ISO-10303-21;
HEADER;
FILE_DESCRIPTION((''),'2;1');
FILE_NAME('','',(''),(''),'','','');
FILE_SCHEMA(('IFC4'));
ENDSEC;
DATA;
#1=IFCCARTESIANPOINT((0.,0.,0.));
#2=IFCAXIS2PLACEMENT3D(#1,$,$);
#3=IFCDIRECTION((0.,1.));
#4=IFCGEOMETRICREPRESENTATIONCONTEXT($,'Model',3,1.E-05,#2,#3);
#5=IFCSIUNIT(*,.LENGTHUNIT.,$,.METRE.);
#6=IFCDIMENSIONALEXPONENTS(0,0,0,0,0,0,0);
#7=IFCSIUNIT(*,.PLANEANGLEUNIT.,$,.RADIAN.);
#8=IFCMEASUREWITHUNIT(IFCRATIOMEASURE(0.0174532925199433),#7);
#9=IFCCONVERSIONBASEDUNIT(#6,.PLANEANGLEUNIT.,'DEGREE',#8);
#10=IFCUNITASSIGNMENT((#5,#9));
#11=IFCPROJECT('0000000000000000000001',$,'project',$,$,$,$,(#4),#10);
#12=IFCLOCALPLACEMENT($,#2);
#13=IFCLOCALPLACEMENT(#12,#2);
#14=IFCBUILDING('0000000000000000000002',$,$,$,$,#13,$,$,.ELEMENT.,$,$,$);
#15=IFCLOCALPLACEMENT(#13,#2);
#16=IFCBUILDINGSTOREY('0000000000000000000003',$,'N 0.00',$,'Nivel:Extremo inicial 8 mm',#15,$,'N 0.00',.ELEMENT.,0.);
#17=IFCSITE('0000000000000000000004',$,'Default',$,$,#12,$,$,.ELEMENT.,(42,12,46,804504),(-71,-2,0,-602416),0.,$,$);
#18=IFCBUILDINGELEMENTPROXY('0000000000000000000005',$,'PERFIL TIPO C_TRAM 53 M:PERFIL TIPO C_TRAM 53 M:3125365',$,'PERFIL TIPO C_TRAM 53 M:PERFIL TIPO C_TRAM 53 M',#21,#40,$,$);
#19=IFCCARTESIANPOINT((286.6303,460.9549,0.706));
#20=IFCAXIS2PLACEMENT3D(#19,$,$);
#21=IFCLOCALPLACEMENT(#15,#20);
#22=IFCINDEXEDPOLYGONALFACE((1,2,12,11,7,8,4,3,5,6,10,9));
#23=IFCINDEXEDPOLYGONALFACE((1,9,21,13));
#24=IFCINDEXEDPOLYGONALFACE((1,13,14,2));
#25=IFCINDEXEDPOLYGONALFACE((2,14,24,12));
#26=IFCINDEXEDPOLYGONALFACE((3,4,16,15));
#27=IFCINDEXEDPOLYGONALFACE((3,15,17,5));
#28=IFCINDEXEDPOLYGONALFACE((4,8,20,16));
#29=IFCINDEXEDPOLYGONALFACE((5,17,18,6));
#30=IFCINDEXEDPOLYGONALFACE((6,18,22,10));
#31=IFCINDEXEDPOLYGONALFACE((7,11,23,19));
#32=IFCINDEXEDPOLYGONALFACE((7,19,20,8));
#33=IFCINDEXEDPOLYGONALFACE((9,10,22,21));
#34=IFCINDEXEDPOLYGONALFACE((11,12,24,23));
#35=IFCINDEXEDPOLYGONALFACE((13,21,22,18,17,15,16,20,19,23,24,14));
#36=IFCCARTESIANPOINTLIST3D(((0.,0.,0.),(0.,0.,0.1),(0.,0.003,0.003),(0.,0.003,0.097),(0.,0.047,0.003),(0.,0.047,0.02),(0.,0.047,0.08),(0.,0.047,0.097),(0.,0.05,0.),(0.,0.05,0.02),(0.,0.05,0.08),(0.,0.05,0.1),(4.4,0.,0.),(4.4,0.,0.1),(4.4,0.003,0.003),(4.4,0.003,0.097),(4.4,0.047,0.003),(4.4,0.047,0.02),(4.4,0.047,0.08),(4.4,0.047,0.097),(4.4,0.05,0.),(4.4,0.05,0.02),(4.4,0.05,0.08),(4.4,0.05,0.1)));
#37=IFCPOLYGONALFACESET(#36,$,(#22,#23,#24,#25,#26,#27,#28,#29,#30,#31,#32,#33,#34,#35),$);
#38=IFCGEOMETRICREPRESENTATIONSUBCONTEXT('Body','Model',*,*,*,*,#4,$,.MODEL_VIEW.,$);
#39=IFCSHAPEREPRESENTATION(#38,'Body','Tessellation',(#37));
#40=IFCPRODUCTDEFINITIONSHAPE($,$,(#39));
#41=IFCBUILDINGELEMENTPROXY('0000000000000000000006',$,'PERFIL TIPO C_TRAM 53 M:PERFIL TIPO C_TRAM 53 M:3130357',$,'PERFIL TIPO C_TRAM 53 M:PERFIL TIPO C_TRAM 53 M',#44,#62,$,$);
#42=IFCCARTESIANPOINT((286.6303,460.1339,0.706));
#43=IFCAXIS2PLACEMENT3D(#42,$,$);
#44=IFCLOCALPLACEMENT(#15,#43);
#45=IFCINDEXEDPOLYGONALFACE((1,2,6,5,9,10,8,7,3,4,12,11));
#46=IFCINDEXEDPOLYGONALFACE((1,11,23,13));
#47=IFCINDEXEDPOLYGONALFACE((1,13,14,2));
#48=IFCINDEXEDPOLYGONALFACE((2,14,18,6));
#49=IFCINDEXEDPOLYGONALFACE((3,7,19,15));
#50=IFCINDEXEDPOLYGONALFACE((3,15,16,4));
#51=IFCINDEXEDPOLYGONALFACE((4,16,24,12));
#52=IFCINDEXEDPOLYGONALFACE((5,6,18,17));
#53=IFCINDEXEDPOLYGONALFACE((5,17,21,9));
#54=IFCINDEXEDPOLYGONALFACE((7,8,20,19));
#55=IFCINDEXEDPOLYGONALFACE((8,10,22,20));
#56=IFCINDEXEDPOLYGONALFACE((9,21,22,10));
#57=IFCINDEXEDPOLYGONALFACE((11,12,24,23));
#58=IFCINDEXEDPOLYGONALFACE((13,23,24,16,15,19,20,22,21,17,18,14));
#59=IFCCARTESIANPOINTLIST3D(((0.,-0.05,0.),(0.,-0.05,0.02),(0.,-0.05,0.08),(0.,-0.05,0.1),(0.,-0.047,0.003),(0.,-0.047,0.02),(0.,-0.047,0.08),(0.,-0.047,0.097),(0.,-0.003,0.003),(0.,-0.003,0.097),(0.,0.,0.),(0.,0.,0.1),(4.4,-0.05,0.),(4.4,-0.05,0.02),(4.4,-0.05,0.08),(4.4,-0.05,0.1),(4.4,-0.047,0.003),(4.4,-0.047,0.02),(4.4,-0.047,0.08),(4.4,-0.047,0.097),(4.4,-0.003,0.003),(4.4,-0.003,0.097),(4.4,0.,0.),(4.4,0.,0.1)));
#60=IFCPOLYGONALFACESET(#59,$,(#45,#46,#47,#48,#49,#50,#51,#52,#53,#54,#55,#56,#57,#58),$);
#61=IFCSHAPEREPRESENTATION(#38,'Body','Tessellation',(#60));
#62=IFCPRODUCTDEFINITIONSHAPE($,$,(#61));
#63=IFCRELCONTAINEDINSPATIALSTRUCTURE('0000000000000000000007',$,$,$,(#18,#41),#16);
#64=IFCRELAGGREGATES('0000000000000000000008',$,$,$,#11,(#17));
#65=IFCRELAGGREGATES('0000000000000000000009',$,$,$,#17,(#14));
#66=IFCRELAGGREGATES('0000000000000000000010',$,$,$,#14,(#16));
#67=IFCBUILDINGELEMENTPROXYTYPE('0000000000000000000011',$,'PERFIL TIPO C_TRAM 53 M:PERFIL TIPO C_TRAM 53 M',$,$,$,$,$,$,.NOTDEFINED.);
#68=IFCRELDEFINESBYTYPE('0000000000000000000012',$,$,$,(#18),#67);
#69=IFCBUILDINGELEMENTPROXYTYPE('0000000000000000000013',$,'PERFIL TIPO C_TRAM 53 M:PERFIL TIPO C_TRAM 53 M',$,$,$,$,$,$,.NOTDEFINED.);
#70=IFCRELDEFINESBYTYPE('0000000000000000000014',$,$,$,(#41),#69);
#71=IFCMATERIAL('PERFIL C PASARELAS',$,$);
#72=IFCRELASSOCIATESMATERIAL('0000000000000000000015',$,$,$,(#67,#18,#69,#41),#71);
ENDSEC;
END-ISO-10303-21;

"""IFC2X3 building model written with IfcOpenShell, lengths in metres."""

from ifc_helpers import new_model, entity, si_unit, converted_unit, direction, frame, origin, place, context, subcontext, project, spatial, polyline, outline, extrude, source, transform, mapped, material, type_object, type_shapes, element, save


model = new_model("IFC2X3")

# Units and contexts
model_context = context("Model", 3, precision=1e-05, world=origin(), true_north=direction((0.0, 1.0)))
body_context = subcontext(model_context, "Body", "Model", "MODEL_VIEW")
ifc_project = project(units=[si_unit("LENGTHUNIT", "METRE"), converted_unit("PLANEANGLEUNIT", "DEGREE", entity("IfcRatioMeasure", 0.0174532925199433), si_unit("PLANEANGLEUNIT", "RADIAN"), dimensions=[0, 0, 0, 0, 0, 0, 0])], contexts=[model_context])

# Site, building, storey
site_placement = place(None, origin())
site = spatial("IfcSite", under=ifc_project, at=site_placement, Name="Default", CompositionType="ELEMENT", RefLatitude=(42, 12, 46, 804504), RefLongitude=(-71, -2, 0, -602416), RefElevation=0.0)
building_placement = place(site_placement, origin())
building = spatial("IfcBuilding", under=site, at=building_placement, CompositionType="ELEMENT")
storey_placement = place(building_placement, origin())
storey = spatial("IfcBuildingStorey", under=building, at=storey_placement, Name="N 0.00", ObjectType="Nivel:Extremo inicial 8 mm", LongName="N 0.00", CompositionType="ELEMENT", Elevation=0.0)

# Building element proxies
ifc_material_1 = material(Name="PERFIL C PASARELAS")
building_element_proxy_type_1 = type_object("IfcBuildingElementProxyType", Name="PERFIL TIPO C_TRAM 53 M:PERFIL TIPO C_TRAM 53 M", PredefinedType="NOTDEFINED", material=ifc_material_1)
shared_shape_1 = source(origin(), body_context, "Body", "SweptSolid", [
    extrude(outline(polyline([(-0.0172, 0.03), (-0.0142, 0.03), (-0.0142, 0.047), (0.0298, 0.047), (0.0298, -0.047), (-0.0142, -0.047), (-0.0142, -0.03), (-0.0172, -0.03), (-0.0172, -0.05), (0.0328, -0.05), (0.0328, 0.05), (-0.0172, 0.05), (-0.0172, 0.03)])), frame((0.0, 0.0328, 0.05), z_axis=(1.0, 0.0, 0.0), x_axis=(0.0, -1.0, 0.0)), (0.0, 0.0, 1.0), 4.4),
])
type_shapes(building_element_proxy_type_1, [shared_shape_1])
proxy_1_placement = place(storey_placement, frame((286.6303, 460.9549, 0.706)))
element("IfcBuildingElementProxy", 1, at=proxy_1_placement, inside=storey, type_object=building_element_proxy_type_1, material=ifc_material_1, Name="PERFIL TIPO C_TRAM 53 M:PERFIL TIPO C_TRAM 53 M:3125365", ObjectType="PERFIL TIPO C_TRAM 53 M:PERFIL TIPO C_TRAM 53 M", context=body_context, shape_type="MappedRepresentation", body=[
    mapped(shared_shape_1, transform((0.0, 0.0, 0.0), scale=1.0)),
])
building_element_proxy_type_2 = type_object("IfcBuildingElementProxyType", Name="PERFIL TIPO C_TRAM 53 M:PERFIL TIPO C_TRAM 53 M", PredefinedType="NOTDEFINED", material=ifc_material_1)
shared_shape_2 = source(origin(), body_context, "Body", "SweptSolid", [
    extrude(outline(polyline([(0.03, -0.0172), (0.05, -0.0172), (0.05, 0.0328), (-0.05, 0.0328), (-0.05, -0.0172), (-0.03, -0.0172), (-0.03, -0.0142), (-0.047, -0.0142), (-0.047, 0.0298), (0.047, 0.0298), (0.047, -0.0142), (0.03, -0.0142), (0.03, -0.0172)])), frame((0.0, -0.0328, 0.05), z_axis=(1.0, 0.0, 0.0), x_axis=(0.0, 0.0, -1.0)), (0.0, 0.0, 1.0), 4.4),
])
type_shapes(building_element_proxy_type_2, [shared_shape_2])
proxy_2_placement = place(storey_placement, frame((286.6303, 460.1339, 0.706)))
element("IfcBuildingElementProxy", 2, at=proxy_2_placement, inside=storey, type_object=building_element_proxy_type_2, material=ifc_material_1, Name="PERFIL TIPO C_TRAM 53 M:PERFIL TIPO C_TRAM 53 M:3130357", ObjectType="PERFIL TIPO C_TRAM 53 M:PERFIL TIPO C_TRAM 53 M", context=body_context, shape_type="MappedRepresentation", body=[
    mapped(shared_shape_2, transform((0.0, 0.0, 0.0), scale=1.0)),
])

save(model, "model.ifc")
